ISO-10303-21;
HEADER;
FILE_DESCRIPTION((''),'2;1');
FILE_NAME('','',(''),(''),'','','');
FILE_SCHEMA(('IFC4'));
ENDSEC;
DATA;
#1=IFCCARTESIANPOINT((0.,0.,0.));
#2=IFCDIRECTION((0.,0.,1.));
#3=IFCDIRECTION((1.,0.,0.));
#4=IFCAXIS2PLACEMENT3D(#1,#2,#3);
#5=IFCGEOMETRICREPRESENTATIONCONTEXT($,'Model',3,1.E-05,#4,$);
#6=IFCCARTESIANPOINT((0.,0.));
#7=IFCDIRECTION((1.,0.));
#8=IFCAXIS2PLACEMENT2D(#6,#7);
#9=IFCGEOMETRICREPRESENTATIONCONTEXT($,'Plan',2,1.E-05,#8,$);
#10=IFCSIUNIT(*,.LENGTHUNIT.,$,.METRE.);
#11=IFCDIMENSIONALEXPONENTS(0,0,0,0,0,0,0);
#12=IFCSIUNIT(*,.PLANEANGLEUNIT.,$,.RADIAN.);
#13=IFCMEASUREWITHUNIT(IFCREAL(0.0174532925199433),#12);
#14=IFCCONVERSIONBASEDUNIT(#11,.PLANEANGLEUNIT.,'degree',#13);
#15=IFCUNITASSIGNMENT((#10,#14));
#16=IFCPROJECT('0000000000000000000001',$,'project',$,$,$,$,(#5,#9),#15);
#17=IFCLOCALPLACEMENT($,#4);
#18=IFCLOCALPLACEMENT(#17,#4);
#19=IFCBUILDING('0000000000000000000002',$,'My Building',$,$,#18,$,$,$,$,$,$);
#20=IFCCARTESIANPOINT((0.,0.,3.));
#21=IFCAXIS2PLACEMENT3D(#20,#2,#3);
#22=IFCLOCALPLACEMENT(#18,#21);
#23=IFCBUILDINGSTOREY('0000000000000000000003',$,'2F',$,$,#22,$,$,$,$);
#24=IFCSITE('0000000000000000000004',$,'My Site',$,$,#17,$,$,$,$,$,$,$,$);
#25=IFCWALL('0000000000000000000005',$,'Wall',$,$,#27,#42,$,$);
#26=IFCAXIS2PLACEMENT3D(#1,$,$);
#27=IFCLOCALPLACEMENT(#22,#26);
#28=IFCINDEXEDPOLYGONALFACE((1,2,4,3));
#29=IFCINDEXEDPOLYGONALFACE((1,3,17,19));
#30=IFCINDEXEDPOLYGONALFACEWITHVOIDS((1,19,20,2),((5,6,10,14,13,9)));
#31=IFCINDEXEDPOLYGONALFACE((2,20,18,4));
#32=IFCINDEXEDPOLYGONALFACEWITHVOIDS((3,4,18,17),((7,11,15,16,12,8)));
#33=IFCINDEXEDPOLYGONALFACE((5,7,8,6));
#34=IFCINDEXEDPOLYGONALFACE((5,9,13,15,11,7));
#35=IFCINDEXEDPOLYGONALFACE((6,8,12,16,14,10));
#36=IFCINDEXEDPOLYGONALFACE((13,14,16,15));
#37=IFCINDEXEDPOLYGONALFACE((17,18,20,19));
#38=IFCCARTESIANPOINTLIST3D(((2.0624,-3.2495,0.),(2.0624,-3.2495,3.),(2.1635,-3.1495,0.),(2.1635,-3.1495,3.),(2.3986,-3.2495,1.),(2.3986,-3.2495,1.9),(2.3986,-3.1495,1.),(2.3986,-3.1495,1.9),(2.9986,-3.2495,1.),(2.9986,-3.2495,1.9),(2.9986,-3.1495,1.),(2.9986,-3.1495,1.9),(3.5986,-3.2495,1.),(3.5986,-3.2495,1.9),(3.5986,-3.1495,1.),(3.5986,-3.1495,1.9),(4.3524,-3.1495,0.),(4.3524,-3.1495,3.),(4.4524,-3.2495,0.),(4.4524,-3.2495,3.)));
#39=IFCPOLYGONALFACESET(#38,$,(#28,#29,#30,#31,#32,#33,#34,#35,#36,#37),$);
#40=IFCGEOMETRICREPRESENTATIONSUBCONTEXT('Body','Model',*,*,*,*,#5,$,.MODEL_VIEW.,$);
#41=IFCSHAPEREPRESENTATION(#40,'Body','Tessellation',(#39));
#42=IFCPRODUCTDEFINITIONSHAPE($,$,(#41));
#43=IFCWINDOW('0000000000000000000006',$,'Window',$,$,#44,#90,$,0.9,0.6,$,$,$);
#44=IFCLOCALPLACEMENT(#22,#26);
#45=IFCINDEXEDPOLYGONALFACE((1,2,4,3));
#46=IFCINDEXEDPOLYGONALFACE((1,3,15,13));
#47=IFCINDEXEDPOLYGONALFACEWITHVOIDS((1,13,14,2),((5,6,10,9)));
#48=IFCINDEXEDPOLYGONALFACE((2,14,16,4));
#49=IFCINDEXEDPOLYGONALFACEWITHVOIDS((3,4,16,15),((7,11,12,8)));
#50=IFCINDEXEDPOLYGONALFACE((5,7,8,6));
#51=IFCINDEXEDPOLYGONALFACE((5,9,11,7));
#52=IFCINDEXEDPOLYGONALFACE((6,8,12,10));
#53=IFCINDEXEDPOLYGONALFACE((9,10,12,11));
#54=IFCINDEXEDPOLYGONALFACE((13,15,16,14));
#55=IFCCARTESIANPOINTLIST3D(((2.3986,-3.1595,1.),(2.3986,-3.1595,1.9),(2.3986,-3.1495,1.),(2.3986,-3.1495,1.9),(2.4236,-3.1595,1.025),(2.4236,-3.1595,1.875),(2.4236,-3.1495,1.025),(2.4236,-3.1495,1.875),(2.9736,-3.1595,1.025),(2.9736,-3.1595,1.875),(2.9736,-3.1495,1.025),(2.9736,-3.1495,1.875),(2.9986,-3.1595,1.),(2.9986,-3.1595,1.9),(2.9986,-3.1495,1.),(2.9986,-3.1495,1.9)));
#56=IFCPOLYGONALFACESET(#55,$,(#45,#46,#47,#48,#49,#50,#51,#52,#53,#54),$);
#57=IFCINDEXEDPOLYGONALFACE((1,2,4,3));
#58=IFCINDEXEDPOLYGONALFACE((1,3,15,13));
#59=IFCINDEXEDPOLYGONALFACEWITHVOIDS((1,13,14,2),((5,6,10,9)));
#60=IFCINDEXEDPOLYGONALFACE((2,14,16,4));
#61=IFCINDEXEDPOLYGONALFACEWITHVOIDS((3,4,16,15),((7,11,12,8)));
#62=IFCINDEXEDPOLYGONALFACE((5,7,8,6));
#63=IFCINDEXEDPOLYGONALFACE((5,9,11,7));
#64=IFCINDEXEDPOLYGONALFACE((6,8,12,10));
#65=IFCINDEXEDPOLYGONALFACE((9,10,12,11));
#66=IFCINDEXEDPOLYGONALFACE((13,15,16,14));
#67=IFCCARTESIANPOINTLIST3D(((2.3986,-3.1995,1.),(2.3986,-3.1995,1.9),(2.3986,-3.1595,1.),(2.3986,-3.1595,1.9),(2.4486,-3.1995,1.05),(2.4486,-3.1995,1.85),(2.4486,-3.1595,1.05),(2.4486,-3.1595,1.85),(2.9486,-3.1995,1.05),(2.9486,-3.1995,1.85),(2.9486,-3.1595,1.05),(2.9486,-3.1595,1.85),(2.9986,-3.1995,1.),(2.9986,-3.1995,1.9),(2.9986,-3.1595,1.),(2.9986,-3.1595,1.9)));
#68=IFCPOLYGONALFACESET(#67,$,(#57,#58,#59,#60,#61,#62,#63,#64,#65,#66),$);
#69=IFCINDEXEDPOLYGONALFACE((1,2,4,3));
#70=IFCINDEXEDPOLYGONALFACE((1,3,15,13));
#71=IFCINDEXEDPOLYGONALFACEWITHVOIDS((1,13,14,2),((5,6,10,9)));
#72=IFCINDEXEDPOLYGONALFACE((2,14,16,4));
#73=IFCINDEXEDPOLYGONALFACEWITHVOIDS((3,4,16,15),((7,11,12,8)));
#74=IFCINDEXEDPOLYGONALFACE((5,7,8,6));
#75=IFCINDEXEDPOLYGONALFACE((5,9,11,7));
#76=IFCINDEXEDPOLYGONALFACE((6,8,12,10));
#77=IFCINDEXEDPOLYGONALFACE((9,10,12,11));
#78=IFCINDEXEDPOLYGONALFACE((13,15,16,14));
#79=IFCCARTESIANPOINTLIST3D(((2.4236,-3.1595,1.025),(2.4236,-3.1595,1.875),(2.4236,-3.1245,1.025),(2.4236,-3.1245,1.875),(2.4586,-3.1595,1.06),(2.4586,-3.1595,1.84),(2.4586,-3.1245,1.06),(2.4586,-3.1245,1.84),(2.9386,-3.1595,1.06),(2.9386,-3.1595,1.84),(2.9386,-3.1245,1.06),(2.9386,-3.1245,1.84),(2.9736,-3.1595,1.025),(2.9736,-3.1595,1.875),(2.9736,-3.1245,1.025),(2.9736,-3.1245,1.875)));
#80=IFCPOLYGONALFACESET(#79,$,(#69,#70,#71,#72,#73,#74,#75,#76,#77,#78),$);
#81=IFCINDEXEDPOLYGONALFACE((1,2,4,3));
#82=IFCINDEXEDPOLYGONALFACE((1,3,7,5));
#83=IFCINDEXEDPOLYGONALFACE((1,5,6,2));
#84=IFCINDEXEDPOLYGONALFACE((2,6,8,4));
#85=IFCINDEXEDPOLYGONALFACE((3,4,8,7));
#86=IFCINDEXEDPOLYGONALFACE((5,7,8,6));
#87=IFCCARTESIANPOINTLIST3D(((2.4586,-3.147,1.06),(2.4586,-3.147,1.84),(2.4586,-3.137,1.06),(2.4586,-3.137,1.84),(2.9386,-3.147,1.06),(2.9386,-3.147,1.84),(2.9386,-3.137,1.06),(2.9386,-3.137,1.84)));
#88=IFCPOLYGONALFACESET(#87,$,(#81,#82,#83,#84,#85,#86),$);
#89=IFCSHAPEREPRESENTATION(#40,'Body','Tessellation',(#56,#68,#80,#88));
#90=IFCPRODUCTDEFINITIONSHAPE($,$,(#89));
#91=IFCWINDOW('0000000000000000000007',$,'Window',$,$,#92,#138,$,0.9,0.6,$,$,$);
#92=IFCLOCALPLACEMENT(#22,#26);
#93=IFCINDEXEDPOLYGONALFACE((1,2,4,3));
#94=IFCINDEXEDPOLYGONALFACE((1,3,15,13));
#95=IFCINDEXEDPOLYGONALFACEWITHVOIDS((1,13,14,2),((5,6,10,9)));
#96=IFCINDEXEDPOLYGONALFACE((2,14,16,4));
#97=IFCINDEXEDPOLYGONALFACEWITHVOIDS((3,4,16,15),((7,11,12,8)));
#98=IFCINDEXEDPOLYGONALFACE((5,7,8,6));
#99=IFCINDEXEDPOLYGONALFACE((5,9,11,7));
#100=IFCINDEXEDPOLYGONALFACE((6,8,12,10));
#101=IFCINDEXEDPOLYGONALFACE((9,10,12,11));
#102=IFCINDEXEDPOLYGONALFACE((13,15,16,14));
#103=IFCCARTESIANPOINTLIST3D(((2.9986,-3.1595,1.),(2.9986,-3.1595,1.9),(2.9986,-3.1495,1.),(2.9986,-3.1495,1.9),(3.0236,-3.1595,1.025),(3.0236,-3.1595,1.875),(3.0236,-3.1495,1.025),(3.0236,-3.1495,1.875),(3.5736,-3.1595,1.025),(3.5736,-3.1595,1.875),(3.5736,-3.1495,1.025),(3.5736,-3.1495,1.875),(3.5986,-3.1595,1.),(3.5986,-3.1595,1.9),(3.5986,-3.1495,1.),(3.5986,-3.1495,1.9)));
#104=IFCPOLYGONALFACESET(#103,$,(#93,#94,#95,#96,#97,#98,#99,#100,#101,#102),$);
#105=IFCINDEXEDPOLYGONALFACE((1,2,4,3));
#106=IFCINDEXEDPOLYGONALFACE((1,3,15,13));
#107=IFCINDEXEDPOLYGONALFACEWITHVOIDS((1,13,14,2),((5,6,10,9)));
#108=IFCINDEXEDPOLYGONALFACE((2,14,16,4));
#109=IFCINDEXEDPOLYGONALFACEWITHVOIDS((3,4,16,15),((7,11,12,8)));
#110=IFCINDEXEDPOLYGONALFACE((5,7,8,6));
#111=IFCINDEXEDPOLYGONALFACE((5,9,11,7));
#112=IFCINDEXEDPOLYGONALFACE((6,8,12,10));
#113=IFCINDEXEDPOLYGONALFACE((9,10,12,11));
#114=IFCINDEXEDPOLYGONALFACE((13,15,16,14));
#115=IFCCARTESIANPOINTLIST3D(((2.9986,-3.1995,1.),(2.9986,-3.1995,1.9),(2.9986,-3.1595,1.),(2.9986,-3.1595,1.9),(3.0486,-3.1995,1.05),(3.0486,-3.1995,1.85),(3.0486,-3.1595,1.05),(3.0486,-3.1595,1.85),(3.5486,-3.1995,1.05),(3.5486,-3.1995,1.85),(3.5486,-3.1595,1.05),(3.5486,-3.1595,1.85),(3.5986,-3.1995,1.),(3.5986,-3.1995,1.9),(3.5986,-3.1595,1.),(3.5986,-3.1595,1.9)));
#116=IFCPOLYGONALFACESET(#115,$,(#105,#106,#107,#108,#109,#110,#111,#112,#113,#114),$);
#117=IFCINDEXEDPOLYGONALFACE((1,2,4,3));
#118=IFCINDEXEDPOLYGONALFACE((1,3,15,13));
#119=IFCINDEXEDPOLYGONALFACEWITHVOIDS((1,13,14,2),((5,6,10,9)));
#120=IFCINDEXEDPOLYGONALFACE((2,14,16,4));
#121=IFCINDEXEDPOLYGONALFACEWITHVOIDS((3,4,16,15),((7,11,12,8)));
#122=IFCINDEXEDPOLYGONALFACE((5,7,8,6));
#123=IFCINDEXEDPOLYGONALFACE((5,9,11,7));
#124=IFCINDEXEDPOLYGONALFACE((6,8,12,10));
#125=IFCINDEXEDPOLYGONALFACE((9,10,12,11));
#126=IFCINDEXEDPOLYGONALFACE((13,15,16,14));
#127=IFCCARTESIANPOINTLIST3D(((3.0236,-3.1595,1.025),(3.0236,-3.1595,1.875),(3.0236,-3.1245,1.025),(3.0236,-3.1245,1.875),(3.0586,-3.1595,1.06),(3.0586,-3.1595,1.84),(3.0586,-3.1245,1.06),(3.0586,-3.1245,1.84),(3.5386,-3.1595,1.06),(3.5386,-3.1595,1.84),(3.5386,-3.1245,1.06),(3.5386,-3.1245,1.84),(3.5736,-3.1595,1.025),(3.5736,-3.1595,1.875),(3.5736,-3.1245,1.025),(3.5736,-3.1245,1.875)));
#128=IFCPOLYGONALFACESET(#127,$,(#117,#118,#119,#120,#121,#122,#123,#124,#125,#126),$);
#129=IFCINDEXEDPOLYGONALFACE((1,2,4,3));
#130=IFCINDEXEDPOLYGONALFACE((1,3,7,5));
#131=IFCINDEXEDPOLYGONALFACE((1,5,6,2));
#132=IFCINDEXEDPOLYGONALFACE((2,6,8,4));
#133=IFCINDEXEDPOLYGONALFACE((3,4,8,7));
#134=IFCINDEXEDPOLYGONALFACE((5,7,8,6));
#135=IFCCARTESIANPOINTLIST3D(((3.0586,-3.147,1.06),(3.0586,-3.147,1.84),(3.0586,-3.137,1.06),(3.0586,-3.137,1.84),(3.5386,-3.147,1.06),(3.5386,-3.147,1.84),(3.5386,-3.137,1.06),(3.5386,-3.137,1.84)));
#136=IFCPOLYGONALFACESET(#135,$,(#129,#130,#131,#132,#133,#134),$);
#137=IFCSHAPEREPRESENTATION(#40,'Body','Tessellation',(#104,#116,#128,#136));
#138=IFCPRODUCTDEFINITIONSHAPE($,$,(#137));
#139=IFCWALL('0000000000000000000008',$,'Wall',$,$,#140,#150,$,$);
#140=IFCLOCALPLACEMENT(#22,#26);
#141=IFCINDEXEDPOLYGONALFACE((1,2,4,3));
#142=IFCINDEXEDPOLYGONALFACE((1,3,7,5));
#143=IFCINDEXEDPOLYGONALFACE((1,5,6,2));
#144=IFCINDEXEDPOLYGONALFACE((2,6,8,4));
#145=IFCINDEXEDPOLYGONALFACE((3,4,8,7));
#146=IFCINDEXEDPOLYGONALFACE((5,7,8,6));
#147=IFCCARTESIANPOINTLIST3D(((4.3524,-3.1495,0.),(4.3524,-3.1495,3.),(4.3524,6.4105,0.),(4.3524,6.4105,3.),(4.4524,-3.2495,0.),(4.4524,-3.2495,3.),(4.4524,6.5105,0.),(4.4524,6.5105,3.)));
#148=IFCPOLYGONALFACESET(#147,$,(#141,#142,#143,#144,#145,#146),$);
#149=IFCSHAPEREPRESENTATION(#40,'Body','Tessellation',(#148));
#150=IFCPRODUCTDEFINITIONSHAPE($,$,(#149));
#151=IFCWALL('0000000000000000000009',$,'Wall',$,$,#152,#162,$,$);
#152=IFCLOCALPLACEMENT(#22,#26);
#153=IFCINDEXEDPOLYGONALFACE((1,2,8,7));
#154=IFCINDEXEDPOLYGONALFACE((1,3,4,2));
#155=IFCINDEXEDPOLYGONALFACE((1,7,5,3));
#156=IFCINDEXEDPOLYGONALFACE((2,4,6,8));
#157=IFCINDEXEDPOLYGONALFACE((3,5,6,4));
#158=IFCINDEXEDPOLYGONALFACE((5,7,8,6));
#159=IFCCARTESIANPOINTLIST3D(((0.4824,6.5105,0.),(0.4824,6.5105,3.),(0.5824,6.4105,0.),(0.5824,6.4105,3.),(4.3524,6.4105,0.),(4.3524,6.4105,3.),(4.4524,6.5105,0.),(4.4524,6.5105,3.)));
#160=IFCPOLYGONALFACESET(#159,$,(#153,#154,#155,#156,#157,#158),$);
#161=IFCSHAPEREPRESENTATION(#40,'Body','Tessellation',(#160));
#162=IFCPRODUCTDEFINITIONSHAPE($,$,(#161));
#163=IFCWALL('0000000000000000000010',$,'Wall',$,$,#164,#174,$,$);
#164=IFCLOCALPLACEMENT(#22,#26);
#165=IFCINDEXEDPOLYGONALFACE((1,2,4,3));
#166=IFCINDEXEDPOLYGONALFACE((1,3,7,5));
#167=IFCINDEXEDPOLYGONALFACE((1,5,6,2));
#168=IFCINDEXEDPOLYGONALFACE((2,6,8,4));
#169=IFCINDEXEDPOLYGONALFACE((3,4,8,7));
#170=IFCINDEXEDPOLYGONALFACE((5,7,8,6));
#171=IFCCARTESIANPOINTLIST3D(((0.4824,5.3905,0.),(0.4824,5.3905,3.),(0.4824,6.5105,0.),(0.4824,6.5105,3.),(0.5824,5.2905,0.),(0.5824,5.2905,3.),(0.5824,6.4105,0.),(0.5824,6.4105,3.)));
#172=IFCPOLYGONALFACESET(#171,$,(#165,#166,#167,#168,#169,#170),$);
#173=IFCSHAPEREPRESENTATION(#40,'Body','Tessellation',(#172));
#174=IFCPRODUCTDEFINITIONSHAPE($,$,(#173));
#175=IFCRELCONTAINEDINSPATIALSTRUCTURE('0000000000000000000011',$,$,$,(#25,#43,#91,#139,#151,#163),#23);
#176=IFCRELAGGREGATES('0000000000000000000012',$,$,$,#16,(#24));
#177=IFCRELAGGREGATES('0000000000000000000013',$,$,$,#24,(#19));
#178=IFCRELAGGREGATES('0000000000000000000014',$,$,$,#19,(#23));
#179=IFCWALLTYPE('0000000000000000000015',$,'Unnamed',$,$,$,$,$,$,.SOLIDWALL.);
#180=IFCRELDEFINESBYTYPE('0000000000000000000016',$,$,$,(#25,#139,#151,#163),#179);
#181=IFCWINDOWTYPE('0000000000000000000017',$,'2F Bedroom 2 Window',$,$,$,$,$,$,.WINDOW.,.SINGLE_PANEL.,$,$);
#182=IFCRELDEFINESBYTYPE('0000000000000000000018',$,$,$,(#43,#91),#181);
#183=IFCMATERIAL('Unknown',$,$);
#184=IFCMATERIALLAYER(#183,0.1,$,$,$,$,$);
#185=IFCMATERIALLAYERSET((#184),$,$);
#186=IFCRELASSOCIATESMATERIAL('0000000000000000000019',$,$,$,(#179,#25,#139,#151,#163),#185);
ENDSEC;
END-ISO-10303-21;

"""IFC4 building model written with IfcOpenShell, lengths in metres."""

from ifc_helpers import new_model, entity, si_unit, converted_unit, frame, origin_with_axes, origin_2d_with_axis, place, context, subcontext, project, spatial, line, indexed_curve, outline, extrude, shape, source, transform, mapped, material, layer, layer_set, layer_usage, type_object, type_shapes, element, fill, save


model = new_model("IFC4")

# Units and contexts
model_context = context("Model", 3, precision=1e-05, world=origin_with_axes())
plan_context = context("Plan", 2, precision=1e-05, world=origin_2d_with_axis())
body_context_1 = subcontext(model_context, "Body", "Model", "MODEL_VIEW")
body_context_2 = subcontext(plan_context, "Body", "Plan", "PLAN_VIEW")
ifc_project = project(units=[si_unit("LENGTHUNIT", "METRE"), converted_unit("PLANEANGLEUNIT", "degree", entity("IfcReal", 0.0174532925199433), si_unit("PLANEANGLEUNIT", "RADIAN"), dimensions=[0, 0, 0, 0, 0, 0, 0])], contexts=[model_context, plan_context])

# Site, building, storey
site_placement = place(None, origin_with_axes())
site = spatial("IfcSite", under=ifc_project, at=site_placement, Name="My Site")
building_placement = place(site_placement, origin_with_axes())
building = spatial("IfcBuilding", under=site, at=building_placement, Name="My Building")
storey_placement = place(building_placement, frame((0.0, 0.0, 3.0), z_axis=(0.0, 0.0, 1.0), x_axis=(1.0, 0.0, 0.0)))
storey = spatial("IfcBuildingStorey", under=building, at=storey_placement, Name="2F")

# Shared definitions
ifc_material = material(Name="Unknown")

# Shared definitions
ifc_layer_1 = layer(ifc_material, 0.1)
ifc_layer_set_1 = layer_set([ifc_layer_1])
wall_type = type_object("IfcWallType", Name="Unnamed", PredefinedType="SOLIDWALL", material=ifc_layer_set_1)

# Wall, openings, windows
ifc_layer_usage_1 = layer_usage(ifc_layer_set_1, "AXIS2", "POSITIVE", 0.0)
wall_1_placement = place(storey_placement, frame((2.0624, -3.2495, 0.0), z_axis=(0.0, 0.0, 1.0), x_axis=(1.0, 0.0, 0.0)))
wall_1 = element("IfcWall", 1, at=wall_1_placement, inside=storey, type_object=wall_type, material=ifc_layer_usage_1, Name="Wall", context=body_context_1, shape_type="SweptSolid", body=[
    extrude(outline(indexed_curve([(0.0, 0.0), (0.1011, 0.1), (2.29, 0.1), (2.39, 0.0)], segments=[line(1, 2, 3, 4, 1)])), origin_with_axes(), (0.0, 0.0, 1.0), 3.0),
])
shared_shape_1 = source(origin_with_axes(), body_context_1, "Body", "SweptSolid", [
    extrude(outline(indexed_curve([(0.0, 0.0), (0.6, 0.0), (0.6, 0.9), (0.0, 0.9)], segments=[line(1, 2, 3, 4, 1)])), frame((0.0, -0.6, 0.0), z_axis=(0.0, -1.0, 0.0), x_axis=(1.0, 0.0, 0.0)), (0.0, 0.0, -1.0), 1.2),
])
opening_1_placement = place(wall_1_placement, frame((0.3362, 0.0, 1.0), z_axis=(0.0, 0.0, 1.0), x_axis=(1.0, 0.0, 0.0)))
opening_1 = element("IfcOpeningElement", 2, at=opening_1_placement, cuts=wall_1, PredefinedType="OPENING", context=body_context_1, shape_type="MappedRepresentation", body=[
    mapped(shared_shape_1, transform((0.0, 0.0, 0.0), x_axis=(1.0, 0.0, 0.0), y_axis=(0.0, 1.0, 0.0), z_axis=(0.0, 0.0, 1.0), scale=1.0)),
])
opening_2_placement = place(wall_1_placement, frame((0.9362, 0.0, 1.0), z_axis=(0.0, 0.0, 1.0), x_axis=(1.0, 0.0, 0.0)))
opening_2 = element("IfcOpeningElement", 3, at=opening_2_placement, cuts=wall_1, PredefinedType="OPENING", context=body_context_1, shape_type="MappedRepresentation", body=[
    mapped(shared_shape_1, transform((0.0, 0.0, 0.0), x_axis=(1.0, 0.0, 0.0), y_axis=(0.0, 1.0, 0.0), z_axis=(0.0, 0.0, 1.0), scale=1.0)),
])
window_type_1 = type_object("IfcWindowType", Name="2F Bedroom 2 Window", PartitioningType="SINGLE_PANEL", PredefinedType="WINDOW")
shared_shape_2 = source(origin_with_axes(), body_context_1, "Body", "SweptSolid", [
    extrude(outline(indexed_curve([(0.0, 0.0), (0.6, 0.0), (0.6, 0.9), (0.0, 0.9)], segments=[line(1, 2, 3, 4, 1)]), holes=[indexed_curve([(0.025, 0.025), (0.575, 0.025), (0.575, 0.875), (0.025, 0.875)], segments=[line(1, 2, 3, 4, 1)])]), frame((0.0, 0.09, 0.0), z_axis=(0.0, -1.0, 0.0), x_axis=(1.0, 0.0, 0.0)), (0.0, 0.0, -1.0), 0.01),
    extrude(outline(indexed_curve([(0.0, 0.0), (0.6, 0.0), (0.6, 0.9), (0.0, 0.9)], segments=[line(1, 2, 3, 4, 1)]), holes=[indexed_curve([(0.05, 0.05), (0.55, 0.05), (0.55, 0.85), (0.05, 0.85)], segments=[line(1, 2, 3, 4, 1)])]), frame((0.0, 0.05, 0.0), z_axis=(0.0, -1.0, 0.0), x_axis=(1.0, 0.0, 0.0)), (0.0, 0.0, -1.0), 0.04),
    extrude(outline(indexed_curve([(0.0, 0.0), (0.55, 0.0), (0.55, 0.85), (0.0, 0.85)], segments=[line(1, 2, 3, 4, 1)]), holes=[indexed_curve([(0.035, 0.035), (0.515, 0.035), (0.515, 0.815), (0.035, 0.815)], segments=[line(1, 2, 3, 4, 1)])]), frame((0.025, 0.09, 0.025), z_axis=(0.0, -1.0, 0.0), x_axis=(1.0, 0.0, 0.0)), (0.0, 0.0, -1.0), 0.035),
    extrude(outline(indexed_curve([(0.035, 0.035), (0.515, 0.035), (0.515, 0.815), (0.035, 0.815)], segments=[line(1, 2, 3, 4, 1)])), frame((0.025, 0.1025, 0.025), z_axis=(0.0, -1.0, 0.0), x_axis=(1.0, 0.0, 0.0)), (0.0, 0.0, -1.0), 0.01),
])
shared_shape_3 = source(origin_with_axes(), body_context_2, "Body", "Curve2D", [
    entity("IfcIndexedPolyCurve", entity("IfcCartesianPointList2D", [[0.05, 0.05], [0.55, 0.05]])),
    entity("IfcIndexedPolyCurve", entity("IfcCartesianPointList2D", [[0.0, 0.1], [0.025, 0.1], [0.025, 0.09], [0.05, 0.09], [0.05, 0.05], [0.0, 0.05]]), [entity("IfcLineIndex", [1, 2, 3, 4, 5, 6, 1])]),
    entity("IfcIndexedPolyCurve", entity("IfcCartesianPointList2D", [[0.6, 0.1], [0.575, 0.1], [0.575, 0.09], [0.55, 0.09], [0.55, 0.05], [0.6, 0.05]]), [entity("IfcLineIndex", [1, 2, 3, 4, 5, 6, 1])]),
    entity("IfcIndexedPolyCurve", entity("IfcCartesianPointList2D", [[0.025, 0.09], [0.06, 0.09], [0.06, 0.125], [0.025, 0.125]]), [entity("IfcLineIndex", [1, 2, 3, 4, 1])]),
    entity("IfcIndexedPolyCurve", entity("IfcCartesianPointList2D", [[0.575, 0.09], [0.54, 0.09], [0.54, 0.125], [0.575, 0.125]]), [entity("IfcLineIndex", [1, 2, 3, 4, 1])]),
    entity("IfcIndexedPolyCurve", entity("IfcCartesianPointList2D", [[0.06, 0.09], [0.54, 0.09]])),
    entity("IfcIndexedPolyCurve", entity("IfcCartesianPointList2D", [[0.06, 0.125], [0.54, 0.125]])),
    entity("IfcIndexedPolyCurve", entity("IfcCartesianPointList2D", [[0.06, 0.1075], [0.54, 0.1075]])),
])
type_shapes(window_type_1, [shared_shape_2, shared_shape_3])
window_1_placement = place(opening_1_placement, origin_with_axes())
window_1 = element("IfcWindow", 4, at=window_1_placement, inside=storey, type_object=window_type_1, Name="Window", OverallHeight=0.9, OverallWidth=0.6, shapes=[
    shape(body_context_1, "Body", "MappedRepresentation", [mapped(shared_shape_2, transform((0.0, 0.0, 0.0), x_axis=(1.0, 0.0, 0.0), y_axis=(0.0, 1.0, 0.0), z_axis=(0.0, 0.0, 1.0), scale=1.0))]),
    shape(body_context_2, "Body", "MappedRepresentation", [mapped(shared_shape_3, transform((0.0, 0.0, 0.0), x_axis=(1.0, 0.0, 0.0), y_axis=(0.0, 1.0, 0.0), z_axis=(0.0, 0.0, 1.0), scale=1.0))]),
])
fill(opening_1, window_1)
window_2_placement = place(opening_2_placement, origin_with_axes())
window_2 = element("IfcWindow", 5, at=window_2_placement, inside=storey, type_object=window_type_1, Name="Window", OverallHeight=0.9, OverallWidth=0.6, shapes=[
    shape(body_context_1, "Body", "MappedRepresentation", [mapped(shared_shape_2, transform((0.0, 0.0, 0.0), x_axis=(1.0, 0.0, 0.0), y_axis=(0.0, 1.0, 0.0), z_axis=(0.0, 0.0, 1.0), scale=1.0))]),
    shape(body_context_2, "Body", "MappedRepresentation", [mapped(shared_shape_3, transform((0.0, 0.0, 0.0), x_axis=(1.0, 0.0, 0.0), y_axis=(0.0, 1.0, 0.0), z_axis=(0.0, 0.0, 1.0), scale=1.0))]),
])
fill(opening_2, window_2)

# Walls
ifc_layer_usage_2 = layer_usage(ifc_layer_set_1, "AXIS2", "POSITIVE", 0.0)
wall_2_placement = place(storey_placement, frame((4.4524, -3.2495, 0.0), z_axis=(0.0, 0.0, 1.0), x_axis=(0.0, 1.0, 0.0)))
element("IfcWall", 6, at=wall_2_placement, inside=storey, type_object=wall_type, material=ifc_layer_usage_2, Name="Wall", context=body_context_1, shape_type="SweptSolid", body=[
    extrude(outline(indexed_curve([(0.0, 0.0), (0.1, 0.1), (9.66, 0.1), (9.76, 0.0)], segments=[line(1, 2, 3, 4, 1)])), origin_with_axes(), (0.0, 0.0, 1.0), 3.0),
])
ifc_layer_usage_3 = layer_usage(ifc_layer_set_1, "AXIS2", "POSITIVE", 0.0)
wall_3_placement = place(storey_placement, frame((4.4524, 6.5105, 0.0), z_axis=(0.0, 0.0, 1.0), x_axis=(-1.0, 0.0, 0.0)))
element("IfcWall", 7, at=wall_3_placement, inside=storey, type_object=wall_type, material=ifc_layer_usage_3, Name="Wall", context=body_context_1, shape_type="SweptSolid", body=[
    extrude(outline(indexed_curve([(0.0, 0.0), (0.1, 0.1), (3.87, 0.1), (3.97, 0.0)], segments=[line(1, 2, 3, 4, 1)])), origin_with_axes(), (0.0, 0.0, 1.0), 3.0),
])
ifc_layer_usage_4 = layer_usage(ifc_layer_set_1, "AXIS2", "POSITIVE", 0.0)
wall_4_placement = place(storey_placement, frame((0.4824, 6.5105, 0.0), z_axis=(0.0, 0.0, 1.0), x_axis=(0.0, -1.0, 0.0)))
element("IfcWall", 8, at=wall_4_placement, inside=storey, type_object=wall_type, material=ifc_layer_usage_4, Name="Wall", context=body_context_1, shape_type="SweptSolid", body=[
    extrude(outline(indexed_curve([(0.0, 0.0), (0.1, 0.1), (1.22, 0.1), (1.12, 0.0)], segments=[line(1, 2, 3, 4, 1)])), origin_with_axes(), (0.0, 0.0, 1.0), 3.0),
])

save(model, "model.ifc")
